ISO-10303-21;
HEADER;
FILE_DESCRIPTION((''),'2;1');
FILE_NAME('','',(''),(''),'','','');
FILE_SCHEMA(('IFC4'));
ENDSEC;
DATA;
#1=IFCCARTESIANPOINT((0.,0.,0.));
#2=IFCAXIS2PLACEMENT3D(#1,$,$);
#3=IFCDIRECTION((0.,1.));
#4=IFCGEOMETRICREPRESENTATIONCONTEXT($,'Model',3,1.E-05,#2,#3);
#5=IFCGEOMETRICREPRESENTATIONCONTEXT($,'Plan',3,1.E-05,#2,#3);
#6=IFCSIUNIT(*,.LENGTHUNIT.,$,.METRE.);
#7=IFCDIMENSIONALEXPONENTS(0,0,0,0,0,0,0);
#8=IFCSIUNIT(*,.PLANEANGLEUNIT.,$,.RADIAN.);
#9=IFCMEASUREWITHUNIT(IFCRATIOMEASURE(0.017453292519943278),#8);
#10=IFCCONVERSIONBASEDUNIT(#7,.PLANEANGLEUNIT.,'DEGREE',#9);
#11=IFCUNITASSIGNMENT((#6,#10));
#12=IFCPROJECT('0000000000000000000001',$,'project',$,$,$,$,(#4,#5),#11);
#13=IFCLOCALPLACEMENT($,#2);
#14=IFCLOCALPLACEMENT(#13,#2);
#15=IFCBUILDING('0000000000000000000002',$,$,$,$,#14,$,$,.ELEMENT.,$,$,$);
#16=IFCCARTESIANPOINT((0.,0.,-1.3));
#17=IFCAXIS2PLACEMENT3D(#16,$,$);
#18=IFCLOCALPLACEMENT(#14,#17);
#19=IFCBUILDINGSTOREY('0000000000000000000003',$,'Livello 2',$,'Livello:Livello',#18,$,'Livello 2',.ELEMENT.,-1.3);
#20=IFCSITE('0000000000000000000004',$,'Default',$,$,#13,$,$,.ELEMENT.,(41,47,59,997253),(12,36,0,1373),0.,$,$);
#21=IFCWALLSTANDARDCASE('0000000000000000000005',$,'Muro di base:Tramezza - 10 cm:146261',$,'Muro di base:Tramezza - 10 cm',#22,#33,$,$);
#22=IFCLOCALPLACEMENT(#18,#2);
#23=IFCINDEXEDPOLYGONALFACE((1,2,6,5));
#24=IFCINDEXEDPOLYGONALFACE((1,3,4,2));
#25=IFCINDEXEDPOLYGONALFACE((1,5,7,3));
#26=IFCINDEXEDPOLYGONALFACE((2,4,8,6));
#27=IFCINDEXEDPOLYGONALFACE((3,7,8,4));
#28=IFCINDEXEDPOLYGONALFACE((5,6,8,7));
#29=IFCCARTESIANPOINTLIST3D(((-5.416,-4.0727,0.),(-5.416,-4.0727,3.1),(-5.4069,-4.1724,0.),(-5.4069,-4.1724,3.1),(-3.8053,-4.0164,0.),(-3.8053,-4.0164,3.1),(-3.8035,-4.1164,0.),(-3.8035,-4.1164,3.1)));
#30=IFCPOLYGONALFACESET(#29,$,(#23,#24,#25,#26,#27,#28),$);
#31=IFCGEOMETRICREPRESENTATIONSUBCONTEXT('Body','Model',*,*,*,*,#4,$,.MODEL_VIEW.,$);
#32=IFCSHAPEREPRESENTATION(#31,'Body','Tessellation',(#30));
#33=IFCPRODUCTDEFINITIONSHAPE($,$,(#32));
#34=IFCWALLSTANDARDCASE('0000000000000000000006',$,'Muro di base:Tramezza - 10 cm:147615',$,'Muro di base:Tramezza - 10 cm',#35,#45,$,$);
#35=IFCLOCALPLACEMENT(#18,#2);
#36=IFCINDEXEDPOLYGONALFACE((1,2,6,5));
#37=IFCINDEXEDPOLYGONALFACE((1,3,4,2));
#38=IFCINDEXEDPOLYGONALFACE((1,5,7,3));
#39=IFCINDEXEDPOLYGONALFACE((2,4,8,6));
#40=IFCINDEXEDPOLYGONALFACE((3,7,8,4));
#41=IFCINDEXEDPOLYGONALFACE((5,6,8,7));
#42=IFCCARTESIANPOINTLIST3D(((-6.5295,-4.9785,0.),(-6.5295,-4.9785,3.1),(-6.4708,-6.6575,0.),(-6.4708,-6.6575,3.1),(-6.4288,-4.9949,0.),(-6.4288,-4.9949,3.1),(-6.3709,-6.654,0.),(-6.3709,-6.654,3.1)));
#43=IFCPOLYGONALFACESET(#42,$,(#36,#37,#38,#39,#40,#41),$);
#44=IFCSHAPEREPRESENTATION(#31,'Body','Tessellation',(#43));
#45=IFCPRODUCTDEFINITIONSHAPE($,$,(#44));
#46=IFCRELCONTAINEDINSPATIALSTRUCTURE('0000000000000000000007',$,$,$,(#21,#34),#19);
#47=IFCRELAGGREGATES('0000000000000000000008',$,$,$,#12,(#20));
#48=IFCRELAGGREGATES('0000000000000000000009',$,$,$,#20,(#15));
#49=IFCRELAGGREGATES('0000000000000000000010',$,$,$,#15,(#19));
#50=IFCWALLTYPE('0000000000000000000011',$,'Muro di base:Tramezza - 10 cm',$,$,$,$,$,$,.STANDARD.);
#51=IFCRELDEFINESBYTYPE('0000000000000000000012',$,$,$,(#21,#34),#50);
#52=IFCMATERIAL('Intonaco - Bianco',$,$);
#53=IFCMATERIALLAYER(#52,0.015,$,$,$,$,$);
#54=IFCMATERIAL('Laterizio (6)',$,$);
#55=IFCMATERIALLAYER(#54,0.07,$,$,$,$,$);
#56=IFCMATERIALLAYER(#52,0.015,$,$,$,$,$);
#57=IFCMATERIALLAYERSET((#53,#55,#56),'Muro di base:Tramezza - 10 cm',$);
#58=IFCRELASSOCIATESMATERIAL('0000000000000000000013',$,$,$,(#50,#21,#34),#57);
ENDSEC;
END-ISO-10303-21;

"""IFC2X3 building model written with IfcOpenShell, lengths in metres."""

from ifc_helpers import new_model, entity, si_unit, converted_unit, direction, frame, origin, place, context, subcontext, project, spatial, polyline, outline, extrude, material, layer, layer_set, layer_usage, type_object, element, save


model = new_model("IFC2X3")

# Units and contexts
model_context = context("Model", 3, precision=1e-05, world=origin(), true_north=direction((0.0, 1.0)))
plan_context = context("Plan", 3, precision=1e-05, world=origin(), true_north=direction((0.0, 1.0)))
body_context = subcontext(model_context, "Body", "Model", "MODEL_VIEW")
ifc_project = project(units=[si_unit("LENGTHUNIT", "METRE"), converted_unit("PLANEANGLEUNIT", "DEGREE", entity("IfcRatioMeasure", 0.017453292519943278), si_unit("PLANEANGLEUNIT", "RADIAN"), dimensions=[0, 0, 0, 0, 0, 0, 0])], contexts=[model_context, plan_context])

# Site, building, storey
site_placement = place(None, origin())
site = spatial("IfcSite", under=ifc_project, at=site_placement, Name="Default", CompositionType="ELEMENT", RefLatitude=(41, 47, 59, 997253), RefLongitude=(12, 36, 0, 1373), RefElevation=0.0)
building_placement = place(site_placement, origin())
building = spatial("IfcBuilding", under=site, at=building_placement, CompositionType="ELEMENT")
storey_placement = place(building_placement, frame((0.0, 0.0, -1.3)))
storey = spatial("IfcBuildingStorey", under=building, at=storey_placement, Name="Livello 2", ObjectType="Livello:Livello", LongName="Livello 2", CompositionType="ELEMENT", Elevation=-1.3)

# Shared definitions
ifc_material_1 = material(Name="Intonaco - Bianco")

# Shared definitions
ifc_material_2 = material(Name="Laterizio (6)")

# Walls
ifc_layer_1 = layer(ifc_material_1, 0.015)
ifc_layer_2 = layer(ifc_material_2, 0.07)
ifc_layer_3 = layer(ifc_material_1, 0.015)
ifc_layer_set_1 = layer_set([ifc_layer_1, ifc_layer_2, ifc_layer_3], Name="Muro di base:Tramezza - 10 cm")
wall_type_1 = type_object("IfcWallType", Name="Muro di base:Tramezza - 10 cm", PredefinedType="STANDARD", material=ifc_layer_set_1)
ifc_layer_usage_1 = layer_usage(ifc_layer_set_1, "AXIS2", "NEGATIVE", 0.05)
wall_1_placement = place(storey_placement, frame((-3.8035, -4.0664, 0.0), z_axis=(0.0, 0.0, 1.0), x_axis=(-0.999391, -0.034899, 0.0)))
element("IfcWallStandardCase", 1, at=wall_1_placement, inside=storey, type_object=wall_type_1, material=ifc_layer_usage_1, Name="Muro di base:Tramezza - 10 cm:146261", ObjectType="Muro di base:Tramezza - 10 cm", context=body_context, shape_type="SweptSolid", body=[
    extrude(outline(polyline([(1.6117, -0.05), (1.6061, 0.05), (0.0017, 0.05), (0.0, -0.05), (1.6117, -0.05)])), origin(), (0.0, 0.0, 1.0), 3.1),
])
ifc_layer_usage_2 = layer_usage(ifc_layer_set_1, "AXIS2", "NEGATIVE", 0.05)
wall_2_placement = place(storey_placement, frame((-6.4209, -6.6557, 0.0), z_axis=(0.0, 0.0, 1.0), x_axis=(-0.034899, 0.999391, 0.0)))
element("IfcWallStandardCase", 2, at=wall_2_placement, inside=storey, type_object=wall_type_1, material=ifc_layer_usage_2, Name="Muro di base:Tramezza - 10 cm:147615", ObjectType="Muro di base:Tramezza - 10 cm", context=body_context, shape_type="SweptSolid", body=[
    extrude(outline(polyline([(1.6601, -0.05), (1.68, 0.05), (0.0, 0.05), (0.0, -0.05), (1.6601, -0.05)])), origin(), (0.0, 0.0, 1.0), 3.1),
])

save(model, "model.ifc")
